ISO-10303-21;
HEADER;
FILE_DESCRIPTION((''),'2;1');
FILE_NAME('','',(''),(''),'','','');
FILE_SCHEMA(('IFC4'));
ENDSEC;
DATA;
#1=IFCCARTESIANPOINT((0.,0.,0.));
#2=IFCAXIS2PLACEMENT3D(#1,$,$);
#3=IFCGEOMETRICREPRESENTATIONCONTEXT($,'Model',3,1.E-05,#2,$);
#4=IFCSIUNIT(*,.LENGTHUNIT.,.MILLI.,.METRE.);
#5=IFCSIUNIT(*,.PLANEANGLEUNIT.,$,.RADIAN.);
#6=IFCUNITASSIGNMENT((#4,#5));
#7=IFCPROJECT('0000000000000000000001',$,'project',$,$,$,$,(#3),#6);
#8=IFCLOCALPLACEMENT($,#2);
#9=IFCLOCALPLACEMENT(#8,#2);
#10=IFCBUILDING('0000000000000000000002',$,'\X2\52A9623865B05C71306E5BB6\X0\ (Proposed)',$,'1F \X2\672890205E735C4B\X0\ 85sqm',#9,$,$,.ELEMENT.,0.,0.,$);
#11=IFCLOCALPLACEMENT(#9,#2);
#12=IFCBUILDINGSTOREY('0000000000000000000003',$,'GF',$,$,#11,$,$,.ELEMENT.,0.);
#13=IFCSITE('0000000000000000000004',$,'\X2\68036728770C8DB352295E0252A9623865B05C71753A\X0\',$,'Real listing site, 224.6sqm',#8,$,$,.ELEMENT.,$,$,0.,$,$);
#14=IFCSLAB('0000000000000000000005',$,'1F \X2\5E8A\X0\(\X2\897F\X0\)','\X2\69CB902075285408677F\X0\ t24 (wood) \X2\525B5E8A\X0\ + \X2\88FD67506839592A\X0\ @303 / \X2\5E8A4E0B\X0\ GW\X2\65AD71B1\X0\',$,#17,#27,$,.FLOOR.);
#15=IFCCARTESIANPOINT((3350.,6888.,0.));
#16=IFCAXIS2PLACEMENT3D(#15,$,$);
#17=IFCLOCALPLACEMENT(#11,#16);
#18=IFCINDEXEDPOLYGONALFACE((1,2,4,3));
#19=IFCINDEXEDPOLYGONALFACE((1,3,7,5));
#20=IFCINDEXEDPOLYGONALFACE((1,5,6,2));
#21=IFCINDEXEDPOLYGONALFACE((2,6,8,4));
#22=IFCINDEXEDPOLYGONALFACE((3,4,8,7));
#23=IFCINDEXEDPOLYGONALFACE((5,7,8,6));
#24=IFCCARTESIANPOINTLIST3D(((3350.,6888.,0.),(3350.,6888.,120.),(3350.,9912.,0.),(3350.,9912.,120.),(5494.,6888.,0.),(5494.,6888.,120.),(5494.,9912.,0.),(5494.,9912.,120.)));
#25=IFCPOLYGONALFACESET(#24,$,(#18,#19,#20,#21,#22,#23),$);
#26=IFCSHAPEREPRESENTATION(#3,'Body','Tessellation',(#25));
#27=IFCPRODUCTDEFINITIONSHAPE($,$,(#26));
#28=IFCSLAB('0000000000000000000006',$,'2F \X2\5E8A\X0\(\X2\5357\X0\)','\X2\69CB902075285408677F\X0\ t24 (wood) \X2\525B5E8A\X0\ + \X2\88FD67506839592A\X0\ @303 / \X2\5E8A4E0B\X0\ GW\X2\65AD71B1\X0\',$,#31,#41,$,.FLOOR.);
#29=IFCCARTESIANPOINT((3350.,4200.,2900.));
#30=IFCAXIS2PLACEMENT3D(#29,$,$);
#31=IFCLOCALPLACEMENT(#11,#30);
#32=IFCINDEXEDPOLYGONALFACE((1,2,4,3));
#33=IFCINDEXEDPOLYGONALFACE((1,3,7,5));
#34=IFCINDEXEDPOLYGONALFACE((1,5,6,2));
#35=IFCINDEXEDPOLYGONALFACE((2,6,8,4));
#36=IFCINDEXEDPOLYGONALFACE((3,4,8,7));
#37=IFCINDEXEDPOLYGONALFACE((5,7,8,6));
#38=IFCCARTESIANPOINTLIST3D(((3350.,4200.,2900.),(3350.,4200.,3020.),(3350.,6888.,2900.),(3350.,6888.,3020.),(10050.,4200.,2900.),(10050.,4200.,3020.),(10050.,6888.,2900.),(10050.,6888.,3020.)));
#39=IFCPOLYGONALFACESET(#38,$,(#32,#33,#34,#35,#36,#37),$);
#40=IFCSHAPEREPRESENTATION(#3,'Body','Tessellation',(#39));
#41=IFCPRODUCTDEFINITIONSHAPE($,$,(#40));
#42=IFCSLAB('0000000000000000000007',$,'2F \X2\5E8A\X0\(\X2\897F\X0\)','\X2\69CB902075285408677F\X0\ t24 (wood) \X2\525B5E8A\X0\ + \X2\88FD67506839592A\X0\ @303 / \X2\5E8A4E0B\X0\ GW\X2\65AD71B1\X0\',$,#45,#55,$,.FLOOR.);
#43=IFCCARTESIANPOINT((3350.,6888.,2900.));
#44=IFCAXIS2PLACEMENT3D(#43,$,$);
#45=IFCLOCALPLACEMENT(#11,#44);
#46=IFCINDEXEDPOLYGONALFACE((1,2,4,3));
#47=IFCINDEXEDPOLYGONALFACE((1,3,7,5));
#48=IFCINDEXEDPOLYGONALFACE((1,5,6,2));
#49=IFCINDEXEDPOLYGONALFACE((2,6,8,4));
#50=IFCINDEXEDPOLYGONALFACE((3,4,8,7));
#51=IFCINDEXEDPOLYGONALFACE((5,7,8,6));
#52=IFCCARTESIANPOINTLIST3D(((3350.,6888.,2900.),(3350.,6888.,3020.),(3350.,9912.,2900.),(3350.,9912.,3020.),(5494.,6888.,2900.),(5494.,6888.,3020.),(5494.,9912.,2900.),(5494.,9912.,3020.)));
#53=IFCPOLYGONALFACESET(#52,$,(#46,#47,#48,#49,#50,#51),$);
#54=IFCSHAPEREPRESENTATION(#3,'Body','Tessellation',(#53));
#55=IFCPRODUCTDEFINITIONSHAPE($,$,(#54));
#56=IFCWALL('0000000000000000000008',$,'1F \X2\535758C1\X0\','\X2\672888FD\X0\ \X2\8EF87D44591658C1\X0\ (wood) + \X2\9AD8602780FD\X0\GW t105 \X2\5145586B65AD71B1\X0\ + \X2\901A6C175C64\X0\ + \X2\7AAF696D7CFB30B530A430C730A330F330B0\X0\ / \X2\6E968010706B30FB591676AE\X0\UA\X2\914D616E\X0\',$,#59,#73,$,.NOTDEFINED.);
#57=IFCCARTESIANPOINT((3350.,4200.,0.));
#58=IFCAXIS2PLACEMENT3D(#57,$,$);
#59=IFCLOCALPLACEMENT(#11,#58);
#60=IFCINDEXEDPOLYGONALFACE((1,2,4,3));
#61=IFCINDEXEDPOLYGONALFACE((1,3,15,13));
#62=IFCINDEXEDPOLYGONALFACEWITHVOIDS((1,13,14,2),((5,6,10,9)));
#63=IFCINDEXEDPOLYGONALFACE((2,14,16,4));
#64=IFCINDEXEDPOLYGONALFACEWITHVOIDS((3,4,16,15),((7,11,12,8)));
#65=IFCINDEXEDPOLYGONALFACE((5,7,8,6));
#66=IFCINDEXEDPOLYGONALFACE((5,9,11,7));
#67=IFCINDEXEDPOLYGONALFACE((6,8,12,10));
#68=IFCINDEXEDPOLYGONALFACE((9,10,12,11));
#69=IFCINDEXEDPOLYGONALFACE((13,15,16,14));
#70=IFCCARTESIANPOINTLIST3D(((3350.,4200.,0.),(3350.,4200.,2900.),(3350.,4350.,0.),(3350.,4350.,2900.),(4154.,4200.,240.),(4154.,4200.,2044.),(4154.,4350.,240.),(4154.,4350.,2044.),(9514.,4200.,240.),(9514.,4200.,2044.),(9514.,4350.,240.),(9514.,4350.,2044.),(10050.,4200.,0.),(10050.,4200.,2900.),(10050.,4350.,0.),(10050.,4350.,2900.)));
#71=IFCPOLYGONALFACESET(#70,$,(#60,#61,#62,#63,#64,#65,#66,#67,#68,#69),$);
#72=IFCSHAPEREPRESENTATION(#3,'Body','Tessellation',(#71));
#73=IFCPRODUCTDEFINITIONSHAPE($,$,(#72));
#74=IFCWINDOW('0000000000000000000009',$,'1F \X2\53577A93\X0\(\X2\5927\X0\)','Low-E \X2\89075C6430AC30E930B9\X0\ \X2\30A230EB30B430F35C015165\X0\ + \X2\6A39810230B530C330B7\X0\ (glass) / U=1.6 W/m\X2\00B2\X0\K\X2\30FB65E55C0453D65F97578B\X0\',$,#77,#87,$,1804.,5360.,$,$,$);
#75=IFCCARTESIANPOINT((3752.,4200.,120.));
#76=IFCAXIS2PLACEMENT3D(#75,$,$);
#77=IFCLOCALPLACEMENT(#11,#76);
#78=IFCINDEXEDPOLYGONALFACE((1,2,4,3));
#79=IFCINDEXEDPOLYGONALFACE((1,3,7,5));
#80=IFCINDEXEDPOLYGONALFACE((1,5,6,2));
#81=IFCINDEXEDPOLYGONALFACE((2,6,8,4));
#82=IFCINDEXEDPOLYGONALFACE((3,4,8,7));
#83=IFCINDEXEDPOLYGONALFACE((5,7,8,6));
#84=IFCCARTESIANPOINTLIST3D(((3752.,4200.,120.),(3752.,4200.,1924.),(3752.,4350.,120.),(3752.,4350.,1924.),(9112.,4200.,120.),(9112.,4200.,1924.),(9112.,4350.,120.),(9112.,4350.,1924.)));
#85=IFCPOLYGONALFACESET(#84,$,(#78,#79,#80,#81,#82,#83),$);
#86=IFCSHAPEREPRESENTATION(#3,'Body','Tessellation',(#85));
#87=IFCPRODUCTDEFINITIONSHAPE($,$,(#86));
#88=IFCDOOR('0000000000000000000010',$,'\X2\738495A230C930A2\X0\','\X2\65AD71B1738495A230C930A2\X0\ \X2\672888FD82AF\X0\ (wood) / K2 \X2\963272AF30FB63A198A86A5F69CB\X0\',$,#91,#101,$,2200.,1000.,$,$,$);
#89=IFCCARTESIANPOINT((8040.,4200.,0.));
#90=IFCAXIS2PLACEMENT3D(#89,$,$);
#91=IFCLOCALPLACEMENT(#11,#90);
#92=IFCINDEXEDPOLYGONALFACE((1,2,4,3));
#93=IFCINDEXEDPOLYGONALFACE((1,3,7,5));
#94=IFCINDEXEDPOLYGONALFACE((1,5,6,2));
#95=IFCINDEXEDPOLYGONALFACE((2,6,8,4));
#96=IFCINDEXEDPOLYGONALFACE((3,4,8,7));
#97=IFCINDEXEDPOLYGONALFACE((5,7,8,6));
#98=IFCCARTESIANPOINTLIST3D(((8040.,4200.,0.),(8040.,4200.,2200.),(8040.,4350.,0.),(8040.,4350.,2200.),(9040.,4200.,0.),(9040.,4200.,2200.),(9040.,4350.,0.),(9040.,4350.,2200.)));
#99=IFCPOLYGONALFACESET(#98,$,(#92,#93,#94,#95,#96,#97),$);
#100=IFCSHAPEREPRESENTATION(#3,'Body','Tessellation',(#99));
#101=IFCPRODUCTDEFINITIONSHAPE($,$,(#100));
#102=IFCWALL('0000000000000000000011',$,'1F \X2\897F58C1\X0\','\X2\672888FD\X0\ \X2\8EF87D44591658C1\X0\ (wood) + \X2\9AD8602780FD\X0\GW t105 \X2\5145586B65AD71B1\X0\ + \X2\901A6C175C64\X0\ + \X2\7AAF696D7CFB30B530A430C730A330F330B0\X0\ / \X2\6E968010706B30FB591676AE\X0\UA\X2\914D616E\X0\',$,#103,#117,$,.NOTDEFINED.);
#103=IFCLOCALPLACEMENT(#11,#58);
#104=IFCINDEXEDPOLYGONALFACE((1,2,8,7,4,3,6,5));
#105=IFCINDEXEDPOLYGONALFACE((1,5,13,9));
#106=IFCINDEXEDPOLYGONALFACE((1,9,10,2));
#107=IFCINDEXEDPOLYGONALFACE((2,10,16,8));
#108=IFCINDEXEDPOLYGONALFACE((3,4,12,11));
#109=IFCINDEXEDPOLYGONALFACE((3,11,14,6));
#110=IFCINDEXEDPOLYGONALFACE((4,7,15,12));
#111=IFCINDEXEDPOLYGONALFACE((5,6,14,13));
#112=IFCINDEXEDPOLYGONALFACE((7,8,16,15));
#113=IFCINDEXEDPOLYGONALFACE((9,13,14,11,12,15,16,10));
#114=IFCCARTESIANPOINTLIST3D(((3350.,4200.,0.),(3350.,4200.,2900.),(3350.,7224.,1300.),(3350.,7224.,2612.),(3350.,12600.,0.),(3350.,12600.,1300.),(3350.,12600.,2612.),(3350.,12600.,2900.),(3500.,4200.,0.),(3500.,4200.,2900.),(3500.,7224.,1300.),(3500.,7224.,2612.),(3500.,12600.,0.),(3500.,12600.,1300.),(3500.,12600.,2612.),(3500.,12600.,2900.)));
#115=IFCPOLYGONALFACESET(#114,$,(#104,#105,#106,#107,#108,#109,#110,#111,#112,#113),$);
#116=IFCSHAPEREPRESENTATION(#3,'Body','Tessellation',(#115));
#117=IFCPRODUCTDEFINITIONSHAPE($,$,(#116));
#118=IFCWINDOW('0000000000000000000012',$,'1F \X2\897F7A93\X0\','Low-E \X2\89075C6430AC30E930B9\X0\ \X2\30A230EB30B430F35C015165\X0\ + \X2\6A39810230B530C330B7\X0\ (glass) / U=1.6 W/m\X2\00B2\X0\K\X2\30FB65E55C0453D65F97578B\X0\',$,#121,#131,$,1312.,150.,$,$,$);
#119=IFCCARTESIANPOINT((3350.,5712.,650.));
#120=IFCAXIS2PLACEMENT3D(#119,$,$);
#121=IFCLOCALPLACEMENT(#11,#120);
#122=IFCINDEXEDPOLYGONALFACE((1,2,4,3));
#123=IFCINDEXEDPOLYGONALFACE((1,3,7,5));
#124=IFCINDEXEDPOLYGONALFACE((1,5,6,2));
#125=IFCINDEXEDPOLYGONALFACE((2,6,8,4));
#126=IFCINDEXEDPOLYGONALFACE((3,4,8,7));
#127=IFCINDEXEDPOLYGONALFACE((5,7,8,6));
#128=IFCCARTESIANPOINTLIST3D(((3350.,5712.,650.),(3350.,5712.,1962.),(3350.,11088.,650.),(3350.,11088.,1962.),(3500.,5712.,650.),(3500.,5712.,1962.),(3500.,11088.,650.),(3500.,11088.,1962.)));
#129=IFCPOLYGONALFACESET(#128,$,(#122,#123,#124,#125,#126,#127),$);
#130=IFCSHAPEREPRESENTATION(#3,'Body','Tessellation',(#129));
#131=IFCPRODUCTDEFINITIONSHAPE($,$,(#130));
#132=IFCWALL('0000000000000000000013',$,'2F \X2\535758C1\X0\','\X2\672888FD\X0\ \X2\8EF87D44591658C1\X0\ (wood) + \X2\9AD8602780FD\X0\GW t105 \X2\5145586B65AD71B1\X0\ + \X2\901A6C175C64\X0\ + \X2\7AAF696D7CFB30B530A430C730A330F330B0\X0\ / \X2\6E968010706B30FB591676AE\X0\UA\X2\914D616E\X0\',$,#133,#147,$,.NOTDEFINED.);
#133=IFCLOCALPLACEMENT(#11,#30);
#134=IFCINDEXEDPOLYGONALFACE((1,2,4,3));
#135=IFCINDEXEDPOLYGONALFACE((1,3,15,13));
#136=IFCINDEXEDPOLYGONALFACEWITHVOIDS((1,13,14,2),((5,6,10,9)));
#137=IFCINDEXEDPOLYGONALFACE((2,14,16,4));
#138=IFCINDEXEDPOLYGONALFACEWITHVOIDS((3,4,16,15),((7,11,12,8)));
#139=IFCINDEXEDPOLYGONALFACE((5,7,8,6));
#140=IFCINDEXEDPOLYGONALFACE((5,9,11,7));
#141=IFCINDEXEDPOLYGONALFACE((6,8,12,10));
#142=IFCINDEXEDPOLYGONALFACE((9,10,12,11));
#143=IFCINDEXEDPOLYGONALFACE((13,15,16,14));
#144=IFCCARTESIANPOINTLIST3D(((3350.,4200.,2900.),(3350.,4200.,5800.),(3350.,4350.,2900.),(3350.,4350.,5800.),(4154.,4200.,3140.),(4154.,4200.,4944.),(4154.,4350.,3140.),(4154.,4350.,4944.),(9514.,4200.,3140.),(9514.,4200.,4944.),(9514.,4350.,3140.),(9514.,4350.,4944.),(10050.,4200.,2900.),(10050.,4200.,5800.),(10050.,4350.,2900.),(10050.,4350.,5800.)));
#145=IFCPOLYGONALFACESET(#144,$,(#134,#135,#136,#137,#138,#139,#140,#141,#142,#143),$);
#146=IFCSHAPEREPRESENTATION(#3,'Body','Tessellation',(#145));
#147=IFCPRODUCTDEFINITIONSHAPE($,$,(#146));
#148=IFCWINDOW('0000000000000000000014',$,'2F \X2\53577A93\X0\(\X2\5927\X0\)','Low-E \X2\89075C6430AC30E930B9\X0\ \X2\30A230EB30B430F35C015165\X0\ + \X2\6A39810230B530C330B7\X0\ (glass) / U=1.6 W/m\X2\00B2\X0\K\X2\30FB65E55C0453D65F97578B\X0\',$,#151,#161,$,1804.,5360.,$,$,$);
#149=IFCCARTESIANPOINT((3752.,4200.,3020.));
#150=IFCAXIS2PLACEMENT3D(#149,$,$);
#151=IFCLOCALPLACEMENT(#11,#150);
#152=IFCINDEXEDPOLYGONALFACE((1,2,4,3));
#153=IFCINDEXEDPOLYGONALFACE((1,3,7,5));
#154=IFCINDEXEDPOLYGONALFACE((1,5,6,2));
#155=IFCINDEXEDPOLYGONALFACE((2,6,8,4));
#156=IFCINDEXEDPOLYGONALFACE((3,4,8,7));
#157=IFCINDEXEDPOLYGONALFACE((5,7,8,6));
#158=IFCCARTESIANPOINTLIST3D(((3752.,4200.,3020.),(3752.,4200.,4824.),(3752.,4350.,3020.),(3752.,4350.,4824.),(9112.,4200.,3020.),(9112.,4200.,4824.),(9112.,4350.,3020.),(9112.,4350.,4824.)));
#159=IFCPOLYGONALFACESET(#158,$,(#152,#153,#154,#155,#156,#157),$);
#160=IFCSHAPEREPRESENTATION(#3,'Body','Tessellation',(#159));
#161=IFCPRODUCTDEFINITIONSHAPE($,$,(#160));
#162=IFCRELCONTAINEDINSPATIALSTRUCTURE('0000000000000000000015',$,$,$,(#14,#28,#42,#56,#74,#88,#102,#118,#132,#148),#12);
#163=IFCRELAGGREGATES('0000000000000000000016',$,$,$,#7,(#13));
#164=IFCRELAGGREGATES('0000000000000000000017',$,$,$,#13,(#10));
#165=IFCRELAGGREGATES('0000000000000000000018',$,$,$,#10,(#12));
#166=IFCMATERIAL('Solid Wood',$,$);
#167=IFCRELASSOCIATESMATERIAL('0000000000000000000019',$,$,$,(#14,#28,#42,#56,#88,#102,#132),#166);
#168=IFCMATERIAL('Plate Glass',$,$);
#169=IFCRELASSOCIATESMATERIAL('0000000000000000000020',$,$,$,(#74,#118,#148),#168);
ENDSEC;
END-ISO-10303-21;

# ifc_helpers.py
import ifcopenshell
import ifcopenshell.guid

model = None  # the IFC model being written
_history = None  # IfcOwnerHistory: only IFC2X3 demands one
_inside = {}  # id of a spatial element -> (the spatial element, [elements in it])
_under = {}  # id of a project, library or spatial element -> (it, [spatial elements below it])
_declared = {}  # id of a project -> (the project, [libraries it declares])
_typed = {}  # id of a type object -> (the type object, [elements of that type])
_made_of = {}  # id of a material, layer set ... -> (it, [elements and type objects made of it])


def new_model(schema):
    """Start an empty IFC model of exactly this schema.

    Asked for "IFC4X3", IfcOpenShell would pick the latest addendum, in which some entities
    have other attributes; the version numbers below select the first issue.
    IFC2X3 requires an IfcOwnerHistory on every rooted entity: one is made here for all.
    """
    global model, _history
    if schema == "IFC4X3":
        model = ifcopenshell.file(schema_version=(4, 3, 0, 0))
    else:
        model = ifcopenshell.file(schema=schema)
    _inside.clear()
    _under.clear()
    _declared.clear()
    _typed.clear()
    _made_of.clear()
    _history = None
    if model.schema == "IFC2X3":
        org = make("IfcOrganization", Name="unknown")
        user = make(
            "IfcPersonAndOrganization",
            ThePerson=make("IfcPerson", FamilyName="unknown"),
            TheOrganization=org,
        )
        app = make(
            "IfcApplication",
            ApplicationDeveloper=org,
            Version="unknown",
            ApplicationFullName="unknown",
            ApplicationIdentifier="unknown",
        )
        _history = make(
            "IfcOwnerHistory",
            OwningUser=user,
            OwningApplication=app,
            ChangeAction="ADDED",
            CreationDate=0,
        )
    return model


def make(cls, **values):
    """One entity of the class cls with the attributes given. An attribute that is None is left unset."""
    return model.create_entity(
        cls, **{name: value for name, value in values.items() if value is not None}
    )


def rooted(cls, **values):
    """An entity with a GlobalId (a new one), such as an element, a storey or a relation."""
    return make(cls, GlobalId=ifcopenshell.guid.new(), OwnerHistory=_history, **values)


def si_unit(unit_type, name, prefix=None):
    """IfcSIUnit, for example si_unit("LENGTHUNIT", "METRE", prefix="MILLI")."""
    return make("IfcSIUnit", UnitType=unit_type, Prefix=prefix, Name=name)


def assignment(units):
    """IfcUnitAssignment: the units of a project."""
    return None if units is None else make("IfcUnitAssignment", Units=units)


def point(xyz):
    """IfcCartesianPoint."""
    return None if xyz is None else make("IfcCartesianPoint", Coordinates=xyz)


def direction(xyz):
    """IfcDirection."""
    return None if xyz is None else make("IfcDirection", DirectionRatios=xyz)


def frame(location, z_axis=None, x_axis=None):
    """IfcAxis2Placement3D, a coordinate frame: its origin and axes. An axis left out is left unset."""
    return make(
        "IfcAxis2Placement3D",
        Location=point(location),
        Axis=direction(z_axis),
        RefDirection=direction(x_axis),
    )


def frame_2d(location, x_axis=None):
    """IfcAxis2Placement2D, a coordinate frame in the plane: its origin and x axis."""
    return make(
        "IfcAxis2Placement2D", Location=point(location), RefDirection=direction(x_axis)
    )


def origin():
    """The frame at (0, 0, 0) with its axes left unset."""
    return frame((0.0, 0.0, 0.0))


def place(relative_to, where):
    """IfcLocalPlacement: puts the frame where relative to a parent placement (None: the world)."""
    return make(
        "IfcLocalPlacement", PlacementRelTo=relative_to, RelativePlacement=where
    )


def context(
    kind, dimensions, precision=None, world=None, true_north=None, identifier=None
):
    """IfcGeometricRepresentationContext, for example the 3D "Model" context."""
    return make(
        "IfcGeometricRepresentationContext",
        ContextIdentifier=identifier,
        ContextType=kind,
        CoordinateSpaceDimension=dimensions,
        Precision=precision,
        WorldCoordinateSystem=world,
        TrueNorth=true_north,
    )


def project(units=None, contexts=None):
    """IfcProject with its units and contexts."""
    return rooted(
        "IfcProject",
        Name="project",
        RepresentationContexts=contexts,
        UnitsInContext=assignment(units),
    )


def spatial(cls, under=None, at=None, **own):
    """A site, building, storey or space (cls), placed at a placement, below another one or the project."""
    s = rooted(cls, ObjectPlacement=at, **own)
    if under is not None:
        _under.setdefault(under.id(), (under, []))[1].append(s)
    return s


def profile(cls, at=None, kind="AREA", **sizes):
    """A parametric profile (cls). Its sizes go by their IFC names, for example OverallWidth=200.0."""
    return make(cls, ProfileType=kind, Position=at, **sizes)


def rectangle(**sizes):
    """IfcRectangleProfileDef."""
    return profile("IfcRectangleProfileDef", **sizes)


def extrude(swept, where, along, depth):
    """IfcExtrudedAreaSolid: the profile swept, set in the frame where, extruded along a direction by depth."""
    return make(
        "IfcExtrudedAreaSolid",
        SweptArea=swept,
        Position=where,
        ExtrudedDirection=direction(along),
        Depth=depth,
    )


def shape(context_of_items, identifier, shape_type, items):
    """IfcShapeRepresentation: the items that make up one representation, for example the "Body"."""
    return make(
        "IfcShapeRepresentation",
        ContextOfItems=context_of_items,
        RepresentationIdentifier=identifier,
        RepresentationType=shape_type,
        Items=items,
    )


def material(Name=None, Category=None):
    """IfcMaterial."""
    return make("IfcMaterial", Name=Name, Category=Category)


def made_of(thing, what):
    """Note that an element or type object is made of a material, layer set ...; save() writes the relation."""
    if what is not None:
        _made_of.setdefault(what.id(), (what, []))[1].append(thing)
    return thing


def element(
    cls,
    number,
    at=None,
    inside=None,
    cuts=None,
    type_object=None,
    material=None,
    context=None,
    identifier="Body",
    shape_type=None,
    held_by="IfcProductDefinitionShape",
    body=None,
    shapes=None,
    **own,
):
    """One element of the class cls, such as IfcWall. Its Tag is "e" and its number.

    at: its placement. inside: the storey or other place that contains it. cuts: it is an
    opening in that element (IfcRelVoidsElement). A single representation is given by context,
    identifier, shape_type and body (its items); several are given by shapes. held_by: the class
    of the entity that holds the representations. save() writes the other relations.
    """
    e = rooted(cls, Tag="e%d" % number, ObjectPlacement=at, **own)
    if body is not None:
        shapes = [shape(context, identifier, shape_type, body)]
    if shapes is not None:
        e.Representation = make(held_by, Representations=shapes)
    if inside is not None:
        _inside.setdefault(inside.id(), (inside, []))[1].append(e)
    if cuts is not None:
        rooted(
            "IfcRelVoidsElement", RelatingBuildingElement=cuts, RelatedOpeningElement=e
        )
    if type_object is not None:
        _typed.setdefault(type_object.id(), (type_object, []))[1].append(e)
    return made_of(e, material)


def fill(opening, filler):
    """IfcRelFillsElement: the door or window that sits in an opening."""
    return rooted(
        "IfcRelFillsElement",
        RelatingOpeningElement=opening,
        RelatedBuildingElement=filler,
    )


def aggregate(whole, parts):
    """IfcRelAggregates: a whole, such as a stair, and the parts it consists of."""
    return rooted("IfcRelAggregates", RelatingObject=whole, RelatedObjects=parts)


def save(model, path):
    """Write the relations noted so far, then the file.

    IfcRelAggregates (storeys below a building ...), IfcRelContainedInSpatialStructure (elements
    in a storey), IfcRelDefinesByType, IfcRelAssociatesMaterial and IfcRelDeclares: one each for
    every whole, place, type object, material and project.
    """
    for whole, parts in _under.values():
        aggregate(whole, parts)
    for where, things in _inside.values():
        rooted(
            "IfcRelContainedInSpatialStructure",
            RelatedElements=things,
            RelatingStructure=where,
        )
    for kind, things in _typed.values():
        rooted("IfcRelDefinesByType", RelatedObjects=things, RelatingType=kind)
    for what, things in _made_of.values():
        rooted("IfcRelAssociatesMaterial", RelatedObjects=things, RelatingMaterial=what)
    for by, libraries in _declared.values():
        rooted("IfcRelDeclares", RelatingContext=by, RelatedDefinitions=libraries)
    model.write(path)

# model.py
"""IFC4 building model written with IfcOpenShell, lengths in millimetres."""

from ifc_helpers import new_model, si_unit, frame, frame_2d, origin, place, context, project, spatial, rectangle, extrude, material, element, fill, save


model = new_model("IFC4")

# Units and contexts
model_context = context("Model", 3, precision=1e-05, world=origin())
ifc_project = project(units=[si_unit("LENGTHUNIT", "METRE", prefix="MILLI"), si_unit("PLANEANGLEUNIT", "RADIAN")], contexts=[model_context])

# Site, building, storey
site_placement = place(None, origin())
site = spatial("IfcSite", under=ifc_project, at=site_placement, Name="栃木県足利市助戸新山町", ObjectType="Real listing site, 224.6sqm", CompositionType="ELEMENT", RefElevation=0.0)
building_placement = place(site_placement, origin())
building = spatial("IfcBuilding", under=site, at=building_placement, Name="助戸新山の家 (Proposed)", ObjectType="1F 木造平屋 85sqm", CompositionType="ELEMENT", ElevationOfRefHeight=0.0, ElevationOfTerrain=0.0)
storey_placement = place(building_placement, origin())
storey = spatial("IfcBuildingStorey", under=building, at=storey_placement, Name="GF", CompositionType="ELEMENT", Elevation=0.0)

# Slabs
ifc_material_1 = material(Name="Solid Wood")
slab_1_placement = place(storey_placement, frame((3350.0, 6888.0, 0.0)))
element("IfcSlab", 1, at=slab_1_placement, inside=storey, material=ifc_material_1, Name="1F 床(西)", Description="構造用合板 t24 (wood) 剛床 + 製材根太 @303 / 床下 GW断熱", PredefinedType="FLOOR", context=model_context, shape_type="SweptSolid", body=[
    extrude(rectangle(XDim=2144.0, YDim=3024.0, at=frame_2d((1072.0, 1512.0))), frame((3350.0, 6888.0, 0.0)), (0.0, 0.0, 1.0), 120.0),
])
slab_2_placement = place(storey_placement, frame((3350.0, 4200.0, 2900.0)))
element("IfcSlab", 2, at=slab_2_placement, inside=storey, material=ifc_material_1, Name="2F 床(南)", Description="構造用合板 t24 (wood) 剛床 + 製材根太 @303 / 床下 GW断熱", PredefinedType="FLOOR", context=model_context, shape_type="SweptSolid", body=[
    extrude(rectangle(XDim=6700.0, YDim=2688.0, at=frame_2d((3350.0, 1344.0))), frame((3350.0, 4200.0, 2900.0)), (0.0, 0.0, 1.0), 120.0),
])
slab_3_placement = place(storey_placement, frame((3350.0, 6888.0, 2900.0)))
element("IfcSlab", 3, at=slab_3_placement, inside=storey, material=ifc_material_1, Name="2F 床(西)", Description="構造用合板 t24 (wood) 剛床 + 製材根太 @303 / 床下 GW断熱", PredefinedType="FLOOR", context=model_context, shape_type="SweptSolid", body=[
    extrude(rectangle(XDim=2144.0, YDim=3024.0, at=frame_2d((1072.0, 1512.0))), frame((3350.0, 6888.0, 2900.0)), (0.0, 0.0, 1.0), 120.0),
])

# Wall, openings, window, door
wall_1_placement = place(storey_placement, frame((3350.0, 4200.0, 0.0)))
wall_1 = element("IfcWall", 4, at=wall_1_placement, inside=storey, material=ifc_material_1, Name="1F 南壁", Description="木製 軸組外壁 (wood) + 高性能GW t105 充填断熱 + 通気層 + 窯業系サイディング / 準耐火・外皮UA配慮", PredefinedType="NOTDEFINED", context=model_context, shape_type="SweptSolid", body=[
    extrude(rectangle(XDim=6700.0, YDim=150.0, at=frame_2d((3350.0, 75.0))), frame((3350.0, 4200.0, 0.0)), (0.0, 0.0, 1.0), 2900.0),
])
opening_1_placement = place(storey_placement, frame((3752.0, 4200.0, 120.0)))
opening_1 = element("IfcOpeningElement", 5, at=opening_1_placement, cuts=wall_1, PredefinedType="NOTDEFINED", context=model_context, shape_type="SweptSolid", body=[
    extrude(rectangle(XDim=5360.0, YDim=150.0, at=frame_2d((2680.0, 75.0))), frame((3752.0, 4200.0, 120.0)), (0.0, 0.0, 1.0), 1804.0),
])
opening_2_placement = place(storey_placement, frame((8040.0, 4200.0, 0.0)))
opening_2 = element("IfcOpeningElement", 6, at=opening_2_placement, cuts=wall_1, PredefinedType="NOTDEFINED", context=model_context, shape_type="SweptSolid", body=[
    extrude(rectangle(XDim=1000.0, YDim=150.0, at=frame_2d((500.0, 75.0))), frame((8040.0, 4200.0, 0.0)), (0.0, 0.0, 1.0), 2200.0),
])
ifc_material_2 = material(Name="Plate Glass")
window_1_placement = place(storey_placement, frame((3752.0, 4200.0, 120.0)))
window_1 = element("IfcWindow", 7, at=window_1_placement, inside=storey, material=ifc_material_2, Name="1F 南窓(大)", Description="Low-E 複層ガラス アルゴン封入 + 樹脂サッシ (glass) / U=1.6 W/m²K・日射取得型", OverallHeight=1804.0, OverallWidth=5360.0, context=model_context, shape_type="SweptSolid", body=[
    extrude(rectangle(XDim=5360.0, YDim=150.0, at=frame_2d((2680.0, 75.0))), frame((3752.0, 4200.0, 120.0)), (0.0, 0.0, 1.0), 1804.0),
])
fill(opening_1, window_1)
door_placement = place(storey_placement, frame((8040.0, 4200.0, 0.0)))
door = element("IfcDoor", 8, at=door_placement, inside=storey, material=ifc_material_1, Name="玄関ドア", Description="断熱玄関ドア 木製芯 (wood) / K2 防犯・採風機構", OverallHeight=2200.0, OverallWidth=1000.0, context=model_context, shape_type="SweptSolid", body=[
    extrude(rectangle(XDim=1000.0, YDim=150.0, at=frame_2d((500.0, 75.0))), frame((8040.0, 4200.0, 0.0)), (0.0, 0.0, 1.0), 2200.0),
])
fill(opening_2, door)

# Walls, openings, windows
wall_2_placement = place(storey_placement, frame((3350.0, 4200.0, 0.0)))
wall_2 = element("IfcWall", 9, at=wall_2_placement, inside=storey, material=ifc_material_1, Name="1F 西壁", Description="木製 軸組外壁 (wood) + 高性能GW t105 充填断熱 + 通気層 + 窯業系サイディング / 準耐火・外皮UA配慮", PredefinedType="NOTDEFINED", context=model_context, shape_type="SweptSolid", body=[
    extrude(rectangle(XDim=150.0, YDim=8400.0, at=frame_2d((75.0, 4200.0))), frame((3350.0, 4200.0, 0.0)), (0.0, 0.0, 1.0), 2900.0),
])
opening_3_placement = place(storey_placement, frame((3350.0, 5712.0, 650.0)))
opening_3 = element("IfcOpeningElement", 10, at=opening_3_placement, cuts=wall_2, PredefinedType="NOTDEFINED", context=model_context, shape_type="SweptSolid", body=[
    extrude(rectangle(XDim=150.0, YDim=5376.0, at=frame_2d((75.0, 2688.0))), frame((3350.0, 5712.0, 650.0)), (0.0, 0.0, 1.0), 1312.0),
])
window_2_placement = place(storey_placement, frame((3350.0, 5712.0, 650.0)))
window_2 = element("IfcWindow", 11, at=window_2_placement, inside=storey, material=ifc_material_2, Name="1F 西窓", Description="Low-E 複層ガラス アルゴン封入 + 樹脂サッシ (glass) / U=1.6 W/m²K・日射取得型", OverallHeight=1312.0, OverallWidth=150.0, context=model_context, shape_type="SweptSolid", body=[
    extrude(rectangle(XDim=150.0, YDim=5376.0, at=frame_2d((75.0, 2688.0))), frame((3350.0, 5712.0, 650.0)), (0.0, 0.0, 1.0), 1312.0),
])
fill(opening_3, window_2)
wall_3_placement = place(storey_placement, frame((3350.0, 4200.0, 2900.0)))
wall_3 = element("IfcWall", 12, at=wall_3_placement, inside=storey, material=ifc_material_1, Name="2F 南壁", Description="木製 軸組外壁 (wood) + 高性能GW t105 充填断熱 + 通気層 + 窯業系サイディング / 準耐火・外皮UA配慮", PredefinedType="NOTDEFINED", context=model_context, shape_type="SweptSolid", body=[
    extrude(rectangle(XDim=6700.0, YDim=150.0, at=frame_2d((3350.0, 75.0))), frame((3350.0, 4200.0, 2900.0)), (0.0, 0.0, 1.0), 2900.0),
])
opening_4_placement = place(storey_placement, frame((3752.0, 4200.0, 3020.0)))
opening_4 = element("IfcOpeningElement", 13, at=opening_4_placement, cuts=wall_3, PredefinedType="NOTDEFINED", context=model_context, shape_type="SweptSolid", body=[
    extrude(rectangle(XDim=5360.0, YDim=150.0, at=frame_2d((2680.0, 75.0))), frame((3752.0, 4200.0, 3020.0)), (0.0, 0.0, 1.0), 1804.0),
])
window_3_placement = place(storey_placement, frame((3752.0, 4200.0, 3020.0)))
window_3 = element("IfcWindow", 14, at=window_3_placement, inside=storey, material=ifc_material_2, Name="2F 南窓(大)", Description="Low-E 複層ガラス アルゴン封入 + 樹脂サッシ (glass) / U=1.6 W/m²K・日射取得型", OverallHeight=1804.0, OverallWidth=5360.0, context=model_context, shape_type="SweptSolid", body=[
    extrude(rectangle(XDim=5360.0, YDim=150.0, at=frame_2d((2680.0, 75.0))), frame((3752.0, 4200.0, 3020.0)), (0.0, 0.0, 1.0), 1804.0),
])
fill(opening_4, window_3)

save(model, "model.ifc")
